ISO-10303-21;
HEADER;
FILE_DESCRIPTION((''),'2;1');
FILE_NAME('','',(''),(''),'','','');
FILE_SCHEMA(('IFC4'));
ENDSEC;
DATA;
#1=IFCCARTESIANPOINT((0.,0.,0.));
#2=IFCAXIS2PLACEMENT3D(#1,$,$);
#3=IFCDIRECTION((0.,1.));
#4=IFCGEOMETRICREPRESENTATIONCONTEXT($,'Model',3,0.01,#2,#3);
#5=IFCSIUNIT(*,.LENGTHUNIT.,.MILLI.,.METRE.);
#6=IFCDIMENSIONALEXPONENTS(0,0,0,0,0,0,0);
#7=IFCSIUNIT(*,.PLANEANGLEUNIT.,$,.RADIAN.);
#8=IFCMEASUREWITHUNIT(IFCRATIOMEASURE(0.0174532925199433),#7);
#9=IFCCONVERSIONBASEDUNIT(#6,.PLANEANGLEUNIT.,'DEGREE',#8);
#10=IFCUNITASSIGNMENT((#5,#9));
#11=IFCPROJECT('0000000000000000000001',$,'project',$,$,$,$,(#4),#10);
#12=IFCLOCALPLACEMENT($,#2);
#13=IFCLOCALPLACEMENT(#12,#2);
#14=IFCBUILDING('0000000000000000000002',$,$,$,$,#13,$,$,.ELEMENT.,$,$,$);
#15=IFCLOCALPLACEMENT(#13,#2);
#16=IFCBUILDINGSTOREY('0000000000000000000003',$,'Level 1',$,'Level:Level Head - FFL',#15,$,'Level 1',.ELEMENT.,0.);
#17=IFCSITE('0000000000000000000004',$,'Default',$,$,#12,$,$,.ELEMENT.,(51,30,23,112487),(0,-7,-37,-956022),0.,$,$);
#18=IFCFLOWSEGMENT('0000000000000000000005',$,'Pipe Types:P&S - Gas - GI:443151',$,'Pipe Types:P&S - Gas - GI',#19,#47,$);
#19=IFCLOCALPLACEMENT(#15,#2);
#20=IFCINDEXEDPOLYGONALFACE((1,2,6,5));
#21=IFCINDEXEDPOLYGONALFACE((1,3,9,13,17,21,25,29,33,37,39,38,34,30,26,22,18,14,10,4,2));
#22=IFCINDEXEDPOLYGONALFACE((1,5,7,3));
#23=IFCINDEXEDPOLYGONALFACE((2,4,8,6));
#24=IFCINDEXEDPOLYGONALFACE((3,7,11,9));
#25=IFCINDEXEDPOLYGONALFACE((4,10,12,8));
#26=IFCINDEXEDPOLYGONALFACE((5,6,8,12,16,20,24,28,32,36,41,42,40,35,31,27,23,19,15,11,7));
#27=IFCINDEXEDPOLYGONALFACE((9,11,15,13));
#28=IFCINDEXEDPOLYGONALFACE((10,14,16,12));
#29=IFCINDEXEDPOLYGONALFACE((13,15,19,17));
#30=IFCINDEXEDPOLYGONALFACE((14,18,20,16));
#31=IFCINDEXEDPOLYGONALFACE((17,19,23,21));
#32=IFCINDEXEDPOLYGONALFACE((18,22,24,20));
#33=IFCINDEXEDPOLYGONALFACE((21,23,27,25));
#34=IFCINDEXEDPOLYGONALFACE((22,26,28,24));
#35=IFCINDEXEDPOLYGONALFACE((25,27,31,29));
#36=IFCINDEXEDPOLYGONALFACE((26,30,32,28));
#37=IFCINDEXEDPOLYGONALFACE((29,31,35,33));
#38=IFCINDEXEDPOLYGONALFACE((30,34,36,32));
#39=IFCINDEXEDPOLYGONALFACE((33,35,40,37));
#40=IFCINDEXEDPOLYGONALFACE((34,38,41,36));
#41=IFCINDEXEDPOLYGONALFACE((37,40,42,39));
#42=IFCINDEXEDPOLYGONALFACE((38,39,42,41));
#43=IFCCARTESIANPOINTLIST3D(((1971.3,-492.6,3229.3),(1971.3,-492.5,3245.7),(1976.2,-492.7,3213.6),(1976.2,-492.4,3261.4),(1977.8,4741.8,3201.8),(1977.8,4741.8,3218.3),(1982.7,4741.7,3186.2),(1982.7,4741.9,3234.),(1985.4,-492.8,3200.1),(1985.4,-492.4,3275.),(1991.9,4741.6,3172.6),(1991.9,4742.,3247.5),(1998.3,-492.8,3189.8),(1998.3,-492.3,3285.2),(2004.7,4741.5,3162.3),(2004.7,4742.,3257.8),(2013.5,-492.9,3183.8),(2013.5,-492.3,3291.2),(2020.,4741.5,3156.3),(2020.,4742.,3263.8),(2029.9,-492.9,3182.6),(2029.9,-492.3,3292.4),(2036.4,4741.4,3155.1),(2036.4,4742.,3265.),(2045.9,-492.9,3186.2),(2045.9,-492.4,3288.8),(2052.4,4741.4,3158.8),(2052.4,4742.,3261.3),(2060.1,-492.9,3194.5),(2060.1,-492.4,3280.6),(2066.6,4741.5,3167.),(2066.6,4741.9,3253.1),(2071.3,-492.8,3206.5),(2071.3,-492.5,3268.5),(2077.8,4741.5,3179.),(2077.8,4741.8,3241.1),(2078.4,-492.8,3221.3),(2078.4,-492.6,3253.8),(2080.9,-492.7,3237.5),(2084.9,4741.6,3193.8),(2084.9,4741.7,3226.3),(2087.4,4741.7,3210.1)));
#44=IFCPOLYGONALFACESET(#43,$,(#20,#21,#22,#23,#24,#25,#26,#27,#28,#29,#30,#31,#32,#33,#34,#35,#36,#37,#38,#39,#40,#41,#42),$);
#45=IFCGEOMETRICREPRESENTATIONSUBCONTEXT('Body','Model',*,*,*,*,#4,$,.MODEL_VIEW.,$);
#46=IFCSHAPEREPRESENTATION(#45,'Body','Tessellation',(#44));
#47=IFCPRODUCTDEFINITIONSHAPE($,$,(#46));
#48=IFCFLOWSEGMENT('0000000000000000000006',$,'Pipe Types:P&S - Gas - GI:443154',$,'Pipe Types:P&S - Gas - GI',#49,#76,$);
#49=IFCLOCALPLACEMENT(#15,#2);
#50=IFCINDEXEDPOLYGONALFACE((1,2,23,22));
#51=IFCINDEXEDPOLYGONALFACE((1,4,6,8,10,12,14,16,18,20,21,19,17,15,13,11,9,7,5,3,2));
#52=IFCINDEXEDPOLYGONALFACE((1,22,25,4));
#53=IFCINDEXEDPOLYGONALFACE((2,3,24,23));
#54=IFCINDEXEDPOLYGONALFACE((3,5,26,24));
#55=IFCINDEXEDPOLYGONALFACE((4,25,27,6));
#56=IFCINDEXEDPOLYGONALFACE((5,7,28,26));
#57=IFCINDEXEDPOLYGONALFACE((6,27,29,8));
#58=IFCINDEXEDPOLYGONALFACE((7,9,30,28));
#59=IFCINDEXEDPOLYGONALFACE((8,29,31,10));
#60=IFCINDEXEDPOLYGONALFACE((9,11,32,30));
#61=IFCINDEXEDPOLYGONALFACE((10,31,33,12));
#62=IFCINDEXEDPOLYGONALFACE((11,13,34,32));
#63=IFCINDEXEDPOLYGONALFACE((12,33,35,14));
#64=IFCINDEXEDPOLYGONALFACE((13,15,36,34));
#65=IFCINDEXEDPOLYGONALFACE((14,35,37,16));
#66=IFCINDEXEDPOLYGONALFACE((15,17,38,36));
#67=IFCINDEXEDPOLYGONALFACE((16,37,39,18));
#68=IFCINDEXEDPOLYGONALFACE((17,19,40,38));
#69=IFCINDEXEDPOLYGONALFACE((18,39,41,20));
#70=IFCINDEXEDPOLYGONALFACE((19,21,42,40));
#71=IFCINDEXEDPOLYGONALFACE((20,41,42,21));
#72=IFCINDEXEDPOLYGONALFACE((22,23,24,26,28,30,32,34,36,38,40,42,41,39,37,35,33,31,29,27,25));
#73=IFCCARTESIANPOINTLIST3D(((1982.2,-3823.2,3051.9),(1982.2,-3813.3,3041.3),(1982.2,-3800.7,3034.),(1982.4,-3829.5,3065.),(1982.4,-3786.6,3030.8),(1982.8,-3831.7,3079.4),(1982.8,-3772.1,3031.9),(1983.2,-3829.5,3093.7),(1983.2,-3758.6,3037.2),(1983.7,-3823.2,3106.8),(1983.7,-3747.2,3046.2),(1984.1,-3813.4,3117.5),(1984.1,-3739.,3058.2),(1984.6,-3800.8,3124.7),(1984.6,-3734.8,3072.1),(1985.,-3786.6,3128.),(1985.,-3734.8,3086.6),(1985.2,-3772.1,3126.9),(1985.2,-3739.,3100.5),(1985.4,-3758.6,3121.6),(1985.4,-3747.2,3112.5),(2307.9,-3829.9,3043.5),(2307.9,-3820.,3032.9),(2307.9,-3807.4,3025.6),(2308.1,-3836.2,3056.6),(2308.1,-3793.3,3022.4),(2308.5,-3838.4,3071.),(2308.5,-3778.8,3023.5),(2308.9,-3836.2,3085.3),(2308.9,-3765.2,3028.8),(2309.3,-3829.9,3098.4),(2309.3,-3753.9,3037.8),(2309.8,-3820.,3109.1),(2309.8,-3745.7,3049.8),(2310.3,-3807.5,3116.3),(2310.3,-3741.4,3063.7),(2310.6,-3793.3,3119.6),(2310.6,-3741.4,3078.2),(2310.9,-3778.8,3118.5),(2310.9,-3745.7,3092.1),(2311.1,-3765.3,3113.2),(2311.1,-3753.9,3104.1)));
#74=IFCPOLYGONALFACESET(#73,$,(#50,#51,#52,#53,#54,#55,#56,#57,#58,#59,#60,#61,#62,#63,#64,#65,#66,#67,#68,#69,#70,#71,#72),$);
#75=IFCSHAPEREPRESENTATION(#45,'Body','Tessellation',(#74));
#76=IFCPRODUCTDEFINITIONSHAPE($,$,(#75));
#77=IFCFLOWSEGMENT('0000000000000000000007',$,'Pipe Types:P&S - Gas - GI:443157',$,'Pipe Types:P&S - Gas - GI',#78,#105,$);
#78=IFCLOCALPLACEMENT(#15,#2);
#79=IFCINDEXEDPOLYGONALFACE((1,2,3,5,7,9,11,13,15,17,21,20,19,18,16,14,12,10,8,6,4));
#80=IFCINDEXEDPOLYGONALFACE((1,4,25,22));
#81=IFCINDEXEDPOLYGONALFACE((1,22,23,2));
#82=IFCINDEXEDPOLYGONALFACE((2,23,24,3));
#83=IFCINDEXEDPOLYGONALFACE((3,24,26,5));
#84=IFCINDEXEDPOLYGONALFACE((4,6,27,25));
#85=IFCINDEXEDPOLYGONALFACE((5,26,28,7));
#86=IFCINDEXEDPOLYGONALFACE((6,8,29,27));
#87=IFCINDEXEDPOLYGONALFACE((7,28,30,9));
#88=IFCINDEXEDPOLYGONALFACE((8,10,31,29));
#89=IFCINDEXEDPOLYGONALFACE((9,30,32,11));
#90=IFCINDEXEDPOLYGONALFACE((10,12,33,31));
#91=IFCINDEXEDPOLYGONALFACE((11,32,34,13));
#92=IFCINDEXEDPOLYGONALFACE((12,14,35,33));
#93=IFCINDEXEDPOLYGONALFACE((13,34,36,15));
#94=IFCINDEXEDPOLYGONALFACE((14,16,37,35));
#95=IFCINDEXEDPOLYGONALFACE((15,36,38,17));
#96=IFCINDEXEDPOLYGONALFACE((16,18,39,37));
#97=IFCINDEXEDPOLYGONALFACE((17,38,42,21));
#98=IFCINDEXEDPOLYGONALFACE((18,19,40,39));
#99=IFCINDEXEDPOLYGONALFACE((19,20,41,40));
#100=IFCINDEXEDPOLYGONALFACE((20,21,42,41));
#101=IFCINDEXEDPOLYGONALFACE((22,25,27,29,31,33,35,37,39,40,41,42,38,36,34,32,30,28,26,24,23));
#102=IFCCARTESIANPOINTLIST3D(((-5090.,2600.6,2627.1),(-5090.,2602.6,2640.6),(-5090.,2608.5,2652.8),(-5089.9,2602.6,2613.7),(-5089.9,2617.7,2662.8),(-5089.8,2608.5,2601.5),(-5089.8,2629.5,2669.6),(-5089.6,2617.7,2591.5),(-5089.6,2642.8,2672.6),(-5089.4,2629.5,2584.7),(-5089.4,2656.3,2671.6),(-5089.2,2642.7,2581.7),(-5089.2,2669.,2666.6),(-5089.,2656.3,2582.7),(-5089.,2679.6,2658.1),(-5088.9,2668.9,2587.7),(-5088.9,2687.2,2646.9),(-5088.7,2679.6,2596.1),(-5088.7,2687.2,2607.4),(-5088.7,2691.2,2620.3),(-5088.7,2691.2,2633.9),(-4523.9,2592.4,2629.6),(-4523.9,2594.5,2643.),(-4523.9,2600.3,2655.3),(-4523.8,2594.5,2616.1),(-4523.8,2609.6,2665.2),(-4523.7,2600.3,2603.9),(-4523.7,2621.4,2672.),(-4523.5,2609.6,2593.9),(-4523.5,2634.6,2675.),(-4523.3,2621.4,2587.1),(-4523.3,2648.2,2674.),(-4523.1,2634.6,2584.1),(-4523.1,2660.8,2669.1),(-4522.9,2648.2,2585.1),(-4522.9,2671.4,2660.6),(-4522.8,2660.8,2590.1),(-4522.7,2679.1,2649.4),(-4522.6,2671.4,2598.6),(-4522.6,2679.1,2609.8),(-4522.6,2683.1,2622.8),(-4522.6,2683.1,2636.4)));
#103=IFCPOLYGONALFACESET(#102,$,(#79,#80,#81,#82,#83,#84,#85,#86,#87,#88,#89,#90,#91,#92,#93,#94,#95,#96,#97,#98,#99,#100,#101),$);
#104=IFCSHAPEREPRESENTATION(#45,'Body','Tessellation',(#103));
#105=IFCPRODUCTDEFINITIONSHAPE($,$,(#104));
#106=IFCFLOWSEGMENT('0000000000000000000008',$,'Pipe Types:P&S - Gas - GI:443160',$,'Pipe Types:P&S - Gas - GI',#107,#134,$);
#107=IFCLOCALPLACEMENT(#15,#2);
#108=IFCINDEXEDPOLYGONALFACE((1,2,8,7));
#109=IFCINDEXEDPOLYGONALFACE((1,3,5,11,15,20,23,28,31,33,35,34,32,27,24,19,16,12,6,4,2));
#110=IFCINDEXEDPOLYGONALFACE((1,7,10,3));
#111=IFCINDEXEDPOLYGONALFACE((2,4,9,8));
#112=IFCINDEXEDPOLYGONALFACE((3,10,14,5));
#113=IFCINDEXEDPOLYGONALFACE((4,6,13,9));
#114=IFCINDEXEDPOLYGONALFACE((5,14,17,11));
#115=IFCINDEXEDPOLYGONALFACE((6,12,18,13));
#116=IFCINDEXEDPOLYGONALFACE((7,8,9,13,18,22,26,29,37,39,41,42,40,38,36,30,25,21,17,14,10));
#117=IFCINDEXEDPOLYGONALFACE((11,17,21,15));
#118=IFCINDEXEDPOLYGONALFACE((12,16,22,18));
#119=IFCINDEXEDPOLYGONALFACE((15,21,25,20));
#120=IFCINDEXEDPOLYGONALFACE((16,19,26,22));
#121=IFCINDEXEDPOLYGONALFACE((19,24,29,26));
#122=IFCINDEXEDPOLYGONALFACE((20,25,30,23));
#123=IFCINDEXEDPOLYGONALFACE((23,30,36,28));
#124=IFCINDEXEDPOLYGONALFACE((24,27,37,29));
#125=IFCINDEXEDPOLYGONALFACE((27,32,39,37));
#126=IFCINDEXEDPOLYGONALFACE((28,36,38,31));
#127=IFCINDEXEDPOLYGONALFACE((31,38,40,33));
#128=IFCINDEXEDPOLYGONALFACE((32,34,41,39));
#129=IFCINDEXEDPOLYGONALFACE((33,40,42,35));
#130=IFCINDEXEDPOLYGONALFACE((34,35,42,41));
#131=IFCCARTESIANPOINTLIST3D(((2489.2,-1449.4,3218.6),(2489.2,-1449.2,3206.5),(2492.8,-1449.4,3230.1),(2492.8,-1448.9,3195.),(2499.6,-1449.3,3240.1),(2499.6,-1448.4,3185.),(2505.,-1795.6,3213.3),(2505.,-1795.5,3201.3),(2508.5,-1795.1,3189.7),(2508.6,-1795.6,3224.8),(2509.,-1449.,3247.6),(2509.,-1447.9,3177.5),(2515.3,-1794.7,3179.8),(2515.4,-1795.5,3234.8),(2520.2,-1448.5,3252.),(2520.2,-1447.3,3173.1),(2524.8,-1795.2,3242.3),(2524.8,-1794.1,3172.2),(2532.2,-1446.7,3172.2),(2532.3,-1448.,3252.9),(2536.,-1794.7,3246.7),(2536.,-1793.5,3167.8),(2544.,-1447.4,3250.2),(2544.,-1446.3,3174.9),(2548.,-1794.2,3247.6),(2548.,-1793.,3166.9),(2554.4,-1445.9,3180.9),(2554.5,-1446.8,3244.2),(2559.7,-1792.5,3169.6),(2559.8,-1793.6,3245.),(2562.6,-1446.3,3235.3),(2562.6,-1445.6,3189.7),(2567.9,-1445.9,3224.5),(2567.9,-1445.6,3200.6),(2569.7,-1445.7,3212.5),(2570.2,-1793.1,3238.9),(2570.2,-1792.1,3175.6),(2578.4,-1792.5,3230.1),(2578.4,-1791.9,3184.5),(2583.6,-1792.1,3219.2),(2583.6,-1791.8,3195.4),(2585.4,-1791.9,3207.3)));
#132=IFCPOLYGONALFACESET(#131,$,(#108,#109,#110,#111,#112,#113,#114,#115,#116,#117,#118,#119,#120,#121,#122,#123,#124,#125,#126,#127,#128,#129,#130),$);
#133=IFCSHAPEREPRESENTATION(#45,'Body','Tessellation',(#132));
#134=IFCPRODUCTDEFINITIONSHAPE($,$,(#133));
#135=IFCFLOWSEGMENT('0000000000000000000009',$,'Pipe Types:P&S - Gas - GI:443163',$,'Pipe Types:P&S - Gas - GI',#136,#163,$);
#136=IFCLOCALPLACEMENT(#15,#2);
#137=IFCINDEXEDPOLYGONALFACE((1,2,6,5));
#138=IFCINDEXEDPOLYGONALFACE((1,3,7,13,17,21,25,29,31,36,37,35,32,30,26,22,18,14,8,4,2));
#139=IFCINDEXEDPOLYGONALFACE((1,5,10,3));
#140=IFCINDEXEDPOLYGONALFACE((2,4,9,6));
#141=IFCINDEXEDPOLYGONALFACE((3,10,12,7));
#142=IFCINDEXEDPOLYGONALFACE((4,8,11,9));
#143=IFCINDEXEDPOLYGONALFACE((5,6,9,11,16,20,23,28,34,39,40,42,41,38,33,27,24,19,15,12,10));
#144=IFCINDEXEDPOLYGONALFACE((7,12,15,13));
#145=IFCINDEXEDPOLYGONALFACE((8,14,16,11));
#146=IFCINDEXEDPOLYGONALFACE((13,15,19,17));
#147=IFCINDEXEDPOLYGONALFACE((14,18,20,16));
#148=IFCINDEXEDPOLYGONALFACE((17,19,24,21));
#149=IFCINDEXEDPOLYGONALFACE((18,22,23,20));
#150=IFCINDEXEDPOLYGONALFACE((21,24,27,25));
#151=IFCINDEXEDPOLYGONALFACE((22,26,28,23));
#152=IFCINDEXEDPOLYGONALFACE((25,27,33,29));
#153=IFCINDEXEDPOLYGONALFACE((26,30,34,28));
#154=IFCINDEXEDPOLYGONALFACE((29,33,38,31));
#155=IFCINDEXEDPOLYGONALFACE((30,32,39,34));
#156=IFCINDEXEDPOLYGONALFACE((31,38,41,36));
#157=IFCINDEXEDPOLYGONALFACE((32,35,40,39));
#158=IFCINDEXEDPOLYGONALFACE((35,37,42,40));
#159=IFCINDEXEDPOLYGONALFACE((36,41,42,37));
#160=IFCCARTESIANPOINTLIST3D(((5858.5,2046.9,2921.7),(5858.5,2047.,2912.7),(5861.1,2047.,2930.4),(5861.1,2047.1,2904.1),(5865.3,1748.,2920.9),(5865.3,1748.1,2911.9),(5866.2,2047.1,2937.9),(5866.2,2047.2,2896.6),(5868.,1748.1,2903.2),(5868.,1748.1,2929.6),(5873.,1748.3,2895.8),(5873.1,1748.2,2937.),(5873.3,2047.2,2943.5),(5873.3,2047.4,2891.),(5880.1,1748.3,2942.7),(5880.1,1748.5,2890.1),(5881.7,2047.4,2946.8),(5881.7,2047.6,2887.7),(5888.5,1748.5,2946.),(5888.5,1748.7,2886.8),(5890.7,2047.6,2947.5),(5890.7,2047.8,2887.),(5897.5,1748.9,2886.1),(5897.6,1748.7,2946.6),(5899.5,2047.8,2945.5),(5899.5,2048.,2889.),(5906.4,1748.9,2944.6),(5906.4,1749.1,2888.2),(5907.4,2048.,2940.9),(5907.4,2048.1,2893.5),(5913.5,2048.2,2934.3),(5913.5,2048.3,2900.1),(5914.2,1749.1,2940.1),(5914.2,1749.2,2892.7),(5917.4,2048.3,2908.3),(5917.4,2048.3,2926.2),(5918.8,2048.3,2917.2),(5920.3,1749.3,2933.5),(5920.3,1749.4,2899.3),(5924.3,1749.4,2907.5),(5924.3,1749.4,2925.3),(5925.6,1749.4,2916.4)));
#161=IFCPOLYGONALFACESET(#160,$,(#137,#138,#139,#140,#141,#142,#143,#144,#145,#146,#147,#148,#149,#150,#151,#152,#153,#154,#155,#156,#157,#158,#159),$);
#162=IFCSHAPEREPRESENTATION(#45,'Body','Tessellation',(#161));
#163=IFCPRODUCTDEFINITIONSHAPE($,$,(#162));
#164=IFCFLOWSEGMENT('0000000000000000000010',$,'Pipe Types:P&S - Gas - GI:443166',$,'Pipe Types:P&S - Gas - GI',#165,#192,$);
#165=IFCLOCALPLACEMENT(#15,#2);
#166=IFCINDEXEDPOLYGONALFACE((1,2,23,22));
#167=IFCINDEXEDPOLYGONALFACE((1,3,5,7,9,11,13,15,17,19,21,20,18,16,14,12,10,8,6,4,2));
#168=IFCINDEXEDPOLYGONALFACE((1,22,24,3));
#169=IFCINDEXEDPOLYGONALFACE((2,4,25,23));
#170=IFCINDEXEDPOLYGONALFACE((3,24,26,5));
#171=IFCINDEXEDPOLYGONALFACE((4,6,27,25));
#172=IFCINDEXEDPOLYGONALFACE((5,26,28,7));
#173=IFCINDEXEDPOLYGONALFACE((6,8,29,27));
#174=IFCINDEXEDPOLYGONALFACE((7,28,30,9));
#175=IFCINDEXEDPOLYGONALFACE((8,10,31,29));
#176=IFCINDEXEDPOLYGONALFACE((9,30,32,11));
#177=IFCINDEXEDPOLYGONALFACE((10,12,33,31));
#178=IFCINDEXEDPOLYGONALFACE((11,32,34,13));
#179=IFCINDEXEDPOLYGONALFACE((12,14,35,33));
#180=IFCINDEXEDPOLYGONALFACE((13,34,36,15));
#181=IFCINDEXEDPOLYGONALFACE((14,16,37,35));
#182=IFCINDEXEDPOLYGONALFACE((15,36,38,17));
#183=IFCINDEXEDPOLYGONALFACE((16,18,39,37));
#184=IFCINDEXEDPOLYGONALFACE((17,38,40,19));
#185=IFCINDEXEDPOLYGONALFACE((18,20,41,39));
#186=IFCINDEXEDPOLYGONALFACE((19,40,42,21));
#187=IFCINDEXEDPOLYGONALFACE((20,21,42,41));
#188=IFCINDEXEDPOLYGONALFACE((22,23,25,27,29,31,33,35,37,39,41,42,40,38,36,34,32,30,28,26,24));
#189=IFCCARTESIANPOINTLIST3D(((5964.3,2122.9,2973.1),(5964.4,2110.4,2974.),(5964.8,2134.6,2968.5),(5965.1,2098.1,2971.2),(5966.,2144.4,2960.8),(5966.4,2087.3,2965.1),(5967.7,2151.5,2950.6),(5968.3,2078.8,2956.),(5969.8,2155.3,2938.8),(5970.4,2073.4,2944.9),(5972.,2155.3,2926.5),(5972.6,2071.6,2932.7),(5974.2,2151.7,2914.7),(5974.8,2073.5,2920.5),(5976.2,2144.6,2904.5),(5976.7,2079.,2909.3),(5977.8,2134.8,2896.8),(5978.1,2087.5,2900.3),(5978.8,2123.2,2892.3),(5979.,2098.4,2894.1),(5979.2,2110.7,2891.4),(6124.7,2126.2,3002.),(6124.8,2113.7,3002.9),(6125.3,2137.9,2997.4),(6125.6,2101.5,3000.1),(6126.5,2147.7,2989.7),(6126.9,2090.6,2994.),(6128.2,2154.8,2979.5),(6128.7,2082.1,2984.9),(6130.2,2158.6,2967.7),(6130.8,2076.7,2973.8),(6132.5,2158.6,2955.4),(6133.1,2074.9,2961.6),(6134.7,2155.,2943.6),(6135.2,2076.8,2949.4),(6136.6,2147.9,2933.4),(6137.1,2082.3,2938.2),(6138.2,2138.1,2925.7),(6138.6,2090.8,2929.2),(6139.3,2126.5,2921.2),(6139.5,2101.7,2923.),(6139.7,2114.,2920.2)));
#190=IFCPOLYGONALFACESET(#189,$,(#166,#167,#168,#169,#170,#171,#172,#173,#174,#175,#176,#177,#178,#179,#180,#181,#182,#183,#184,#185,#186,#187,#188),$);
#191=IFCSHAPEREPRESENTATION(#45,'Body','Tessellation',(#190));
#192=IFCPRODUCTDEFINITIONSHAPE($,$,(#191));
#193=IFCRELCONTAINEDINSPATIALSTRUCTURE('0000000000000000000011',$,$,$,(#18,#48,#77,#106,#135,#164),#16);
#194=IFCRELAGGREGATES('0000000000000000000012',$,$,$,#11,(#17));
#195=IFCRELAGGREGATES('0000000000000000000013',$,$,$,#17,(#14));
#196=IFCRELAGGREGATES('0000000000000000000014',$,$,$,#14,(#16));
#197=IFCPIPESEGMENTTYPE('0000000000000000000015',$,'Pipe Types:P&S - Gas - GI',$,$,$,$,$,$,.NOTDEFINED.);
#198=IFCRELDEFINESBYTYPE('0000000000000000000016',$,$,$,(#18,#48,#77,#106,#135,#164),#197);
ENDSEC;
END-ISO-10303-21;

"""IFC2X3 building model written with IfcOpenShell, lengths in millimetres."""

from ifc_helpers import new_model, entity, si_unit, converted_unit, direction, frame, frame_2d, origin, origin_2d_with_axis, place, context, subcontext, project, spatial, circle, extrude, type_object, element, save


model = new_model("IFC2X3")

# Units and contexts
model_context = context("Model", 3, precision=0.01, world=origin(), true_north=direction((0.0, 1.0)))
body_context = subcontext(model_context, "Body", "Model", "MODEL_VIEW")
ifc_project = project(units=[si_unit("LENGTHUNIT", "METRE", prefix="MILLI"), converted_unit("PLANEANGLEUNIT", "DEGREE", entity("IfcRatioMeasure", 0.0174532925199433), si_unit("PLANEANGLEUNIT", "RADIAN"), dimensions=[0, 0, 0, 0, 0, 0, 0])], contexts=[model_context])

# Site, building, storey
site_placement = place(None, origin())
site = spatial("IfcSite", under=ifc_project, at=site_placement, Name="Default", CompositionType="ELEMENT", RefLatitude=(51, 30, 23, 112487), RefLongitude=(0, -7, -37, -956022), RefElevation=0.0)
building_placement = place(site_placement, origin())
building = spatial("IfcBuilding", under=site, at=building_placement, CompositionType="ELEMENT")
storey_placement = place(building_placement, origin())
storey = spatial("IfcBuildingStorey", under=building, at=storey_placement, Name="Level 1", ObjectType="Level:Level Head - FFL", LongName="Level 1", CompositionType="ELEMENT", Elevation=0.0)

# Flow segments
pipe_segment_type = type_object("IfcPipeSegmentType", Name="Pipe Types:P&S - Gas - GI", PredefinedType="NOTDEFINED")
flow_segment_1_placement = place(storey_placement, origin())
element("IfcFlowSegment", 1, at=flow_segment_1_placement, inside=storey, type_object=pipe_segment_type, Name="Pipe Types:P&S - Gas - GI:443151", ObjectType="Pipe Types:P&S - Gas - GI", context=body_context, shape_type="SweptSolid", body=[
    extrude(circle(Radius=55.1, at=frame_2d((0.0, 0.0), x_axis=(1.0, 0.0))), frame((2025.8, -492.6, 3237.5), z_axis=(0.001239, 0.999985, -0.005248), x_axis=(0.999999, -0.001239, 0.0)), (0.0, 0.0, 1.0), 5234.4),
])
flow_segment_2_placement = place(storey_placement, origin())
element("IfcFlowSegment", 2, at=flow_segment_2_placement, inside=storey, type_object=pipe_segment_type, Name="Pipe Types:P&S - Gas - GI:443154", ObjectType="Pipe Types:P&S - Gas - GI", context=body_context, shape_type="SweptSolid", body=[
    extrude(circle(Radius=48.7, at=origin_2d_with_axis()), frame((2309.5, -3789.6, 3071.0), z_axis=(-0.999458, 0.020523, 0.025732), x_axis=(-0.020529, -0.999789, 0.0)), (0.0, 0.0, 1.0), 325.9),
])
flow_segment_3_placement = place(storey_placement, origin())
element("IfcFlowSegment", 3, at=flow_segment_3_placement, inside=storey, type_object=pipe_segment_type, Name="Pipe Types:P&S - Gas - GI:443157", ObjectType="Pipe Types:P&S - Gas - GI", context=body_context, shape_type="SweptSolid", body=[
    extrude(circle(Radius=45.6, at=frame_2d((0.0, 0.0), x_axis=(1.0, 0.0))), frame((-5089.4, 2646.2, 2627.1), z_axis=(0.999887, -0.014382, 0.004296), x_axis=(-0.014383, -0.999897, 0.0)), (0.0, 0.0, 1.0), 566.2),
])
flow_segment_4_placement = place(storey_placement, origin())
element("IfcFlowSegment", 4, at=flow_segment_4_placement, inside=storey, type_object=pipe_segment_type, Name="Pipe Types:P&S - Gas - GI:443160", ObjectType="Pipe Types:P&S - Gas - GI", context=body_context, shape_type="SweptSolid", body=[
    extrude(circle(Radius=40.5, at=frame_2d((0.0, 0.0), x_axis=(1.0, 0.0))), frame((2529.2, -1447.5, 3212.5), z_axis=(0.045525, -0.998848, -0.015163), x_axis=(0.998963, 0.04553, 0.0)), (0.0, 0.0, 1.0), 346.6),
])
flow_segment_5_placement = place(storey_placement, origin())
element("IfcFlowSegment", 5, at=flow_segment_5_placement, inside=storey, type_object=pipe_segment_type, Name="Pipe Types:P&S - Gas - GI:443163", ObjectType="Pipe Types:P&S - Gas - GI", context=body_context, shape_type="SweptSolid", body=[
    extrude(circle(Radius=30.3, at=origin_2d_with_axis()), frame((5895.3, 1748.7, 2916.4), z_axis=(-0.022834, 0.999735, 0.002778), x_axis=(0.999739, 0.022834, 0.0)), (0.0, 0.0, 1.0), 299.0),
])
flow_segment_6_placement = place(storey_placement, origin())
element("IfcFlowSegment", 6, at=flow_segment_6_placement, inside=storey, type_object=pipe_segment_type, Name="Pipe Types:P&S - Gas - GI:443166", ObjectType="Pipe Types:P&S - Gas - GI", context=body_context, shape_type="SweptSolid", body=[
    extrude(circle(Radius=42.1, at=frame_2d((0.0, 0.0), x_axis=(1.0, 0.0))), frame((5971.7, 2113.7, 2932.7), z_axis=(0.983968, 0.020258, 0.177189), x_axis=(0.020584, -0.999788, 0.0)), (0.0, 0.0, 1.0), 163.1),
])

save(model, "model.ifc")
